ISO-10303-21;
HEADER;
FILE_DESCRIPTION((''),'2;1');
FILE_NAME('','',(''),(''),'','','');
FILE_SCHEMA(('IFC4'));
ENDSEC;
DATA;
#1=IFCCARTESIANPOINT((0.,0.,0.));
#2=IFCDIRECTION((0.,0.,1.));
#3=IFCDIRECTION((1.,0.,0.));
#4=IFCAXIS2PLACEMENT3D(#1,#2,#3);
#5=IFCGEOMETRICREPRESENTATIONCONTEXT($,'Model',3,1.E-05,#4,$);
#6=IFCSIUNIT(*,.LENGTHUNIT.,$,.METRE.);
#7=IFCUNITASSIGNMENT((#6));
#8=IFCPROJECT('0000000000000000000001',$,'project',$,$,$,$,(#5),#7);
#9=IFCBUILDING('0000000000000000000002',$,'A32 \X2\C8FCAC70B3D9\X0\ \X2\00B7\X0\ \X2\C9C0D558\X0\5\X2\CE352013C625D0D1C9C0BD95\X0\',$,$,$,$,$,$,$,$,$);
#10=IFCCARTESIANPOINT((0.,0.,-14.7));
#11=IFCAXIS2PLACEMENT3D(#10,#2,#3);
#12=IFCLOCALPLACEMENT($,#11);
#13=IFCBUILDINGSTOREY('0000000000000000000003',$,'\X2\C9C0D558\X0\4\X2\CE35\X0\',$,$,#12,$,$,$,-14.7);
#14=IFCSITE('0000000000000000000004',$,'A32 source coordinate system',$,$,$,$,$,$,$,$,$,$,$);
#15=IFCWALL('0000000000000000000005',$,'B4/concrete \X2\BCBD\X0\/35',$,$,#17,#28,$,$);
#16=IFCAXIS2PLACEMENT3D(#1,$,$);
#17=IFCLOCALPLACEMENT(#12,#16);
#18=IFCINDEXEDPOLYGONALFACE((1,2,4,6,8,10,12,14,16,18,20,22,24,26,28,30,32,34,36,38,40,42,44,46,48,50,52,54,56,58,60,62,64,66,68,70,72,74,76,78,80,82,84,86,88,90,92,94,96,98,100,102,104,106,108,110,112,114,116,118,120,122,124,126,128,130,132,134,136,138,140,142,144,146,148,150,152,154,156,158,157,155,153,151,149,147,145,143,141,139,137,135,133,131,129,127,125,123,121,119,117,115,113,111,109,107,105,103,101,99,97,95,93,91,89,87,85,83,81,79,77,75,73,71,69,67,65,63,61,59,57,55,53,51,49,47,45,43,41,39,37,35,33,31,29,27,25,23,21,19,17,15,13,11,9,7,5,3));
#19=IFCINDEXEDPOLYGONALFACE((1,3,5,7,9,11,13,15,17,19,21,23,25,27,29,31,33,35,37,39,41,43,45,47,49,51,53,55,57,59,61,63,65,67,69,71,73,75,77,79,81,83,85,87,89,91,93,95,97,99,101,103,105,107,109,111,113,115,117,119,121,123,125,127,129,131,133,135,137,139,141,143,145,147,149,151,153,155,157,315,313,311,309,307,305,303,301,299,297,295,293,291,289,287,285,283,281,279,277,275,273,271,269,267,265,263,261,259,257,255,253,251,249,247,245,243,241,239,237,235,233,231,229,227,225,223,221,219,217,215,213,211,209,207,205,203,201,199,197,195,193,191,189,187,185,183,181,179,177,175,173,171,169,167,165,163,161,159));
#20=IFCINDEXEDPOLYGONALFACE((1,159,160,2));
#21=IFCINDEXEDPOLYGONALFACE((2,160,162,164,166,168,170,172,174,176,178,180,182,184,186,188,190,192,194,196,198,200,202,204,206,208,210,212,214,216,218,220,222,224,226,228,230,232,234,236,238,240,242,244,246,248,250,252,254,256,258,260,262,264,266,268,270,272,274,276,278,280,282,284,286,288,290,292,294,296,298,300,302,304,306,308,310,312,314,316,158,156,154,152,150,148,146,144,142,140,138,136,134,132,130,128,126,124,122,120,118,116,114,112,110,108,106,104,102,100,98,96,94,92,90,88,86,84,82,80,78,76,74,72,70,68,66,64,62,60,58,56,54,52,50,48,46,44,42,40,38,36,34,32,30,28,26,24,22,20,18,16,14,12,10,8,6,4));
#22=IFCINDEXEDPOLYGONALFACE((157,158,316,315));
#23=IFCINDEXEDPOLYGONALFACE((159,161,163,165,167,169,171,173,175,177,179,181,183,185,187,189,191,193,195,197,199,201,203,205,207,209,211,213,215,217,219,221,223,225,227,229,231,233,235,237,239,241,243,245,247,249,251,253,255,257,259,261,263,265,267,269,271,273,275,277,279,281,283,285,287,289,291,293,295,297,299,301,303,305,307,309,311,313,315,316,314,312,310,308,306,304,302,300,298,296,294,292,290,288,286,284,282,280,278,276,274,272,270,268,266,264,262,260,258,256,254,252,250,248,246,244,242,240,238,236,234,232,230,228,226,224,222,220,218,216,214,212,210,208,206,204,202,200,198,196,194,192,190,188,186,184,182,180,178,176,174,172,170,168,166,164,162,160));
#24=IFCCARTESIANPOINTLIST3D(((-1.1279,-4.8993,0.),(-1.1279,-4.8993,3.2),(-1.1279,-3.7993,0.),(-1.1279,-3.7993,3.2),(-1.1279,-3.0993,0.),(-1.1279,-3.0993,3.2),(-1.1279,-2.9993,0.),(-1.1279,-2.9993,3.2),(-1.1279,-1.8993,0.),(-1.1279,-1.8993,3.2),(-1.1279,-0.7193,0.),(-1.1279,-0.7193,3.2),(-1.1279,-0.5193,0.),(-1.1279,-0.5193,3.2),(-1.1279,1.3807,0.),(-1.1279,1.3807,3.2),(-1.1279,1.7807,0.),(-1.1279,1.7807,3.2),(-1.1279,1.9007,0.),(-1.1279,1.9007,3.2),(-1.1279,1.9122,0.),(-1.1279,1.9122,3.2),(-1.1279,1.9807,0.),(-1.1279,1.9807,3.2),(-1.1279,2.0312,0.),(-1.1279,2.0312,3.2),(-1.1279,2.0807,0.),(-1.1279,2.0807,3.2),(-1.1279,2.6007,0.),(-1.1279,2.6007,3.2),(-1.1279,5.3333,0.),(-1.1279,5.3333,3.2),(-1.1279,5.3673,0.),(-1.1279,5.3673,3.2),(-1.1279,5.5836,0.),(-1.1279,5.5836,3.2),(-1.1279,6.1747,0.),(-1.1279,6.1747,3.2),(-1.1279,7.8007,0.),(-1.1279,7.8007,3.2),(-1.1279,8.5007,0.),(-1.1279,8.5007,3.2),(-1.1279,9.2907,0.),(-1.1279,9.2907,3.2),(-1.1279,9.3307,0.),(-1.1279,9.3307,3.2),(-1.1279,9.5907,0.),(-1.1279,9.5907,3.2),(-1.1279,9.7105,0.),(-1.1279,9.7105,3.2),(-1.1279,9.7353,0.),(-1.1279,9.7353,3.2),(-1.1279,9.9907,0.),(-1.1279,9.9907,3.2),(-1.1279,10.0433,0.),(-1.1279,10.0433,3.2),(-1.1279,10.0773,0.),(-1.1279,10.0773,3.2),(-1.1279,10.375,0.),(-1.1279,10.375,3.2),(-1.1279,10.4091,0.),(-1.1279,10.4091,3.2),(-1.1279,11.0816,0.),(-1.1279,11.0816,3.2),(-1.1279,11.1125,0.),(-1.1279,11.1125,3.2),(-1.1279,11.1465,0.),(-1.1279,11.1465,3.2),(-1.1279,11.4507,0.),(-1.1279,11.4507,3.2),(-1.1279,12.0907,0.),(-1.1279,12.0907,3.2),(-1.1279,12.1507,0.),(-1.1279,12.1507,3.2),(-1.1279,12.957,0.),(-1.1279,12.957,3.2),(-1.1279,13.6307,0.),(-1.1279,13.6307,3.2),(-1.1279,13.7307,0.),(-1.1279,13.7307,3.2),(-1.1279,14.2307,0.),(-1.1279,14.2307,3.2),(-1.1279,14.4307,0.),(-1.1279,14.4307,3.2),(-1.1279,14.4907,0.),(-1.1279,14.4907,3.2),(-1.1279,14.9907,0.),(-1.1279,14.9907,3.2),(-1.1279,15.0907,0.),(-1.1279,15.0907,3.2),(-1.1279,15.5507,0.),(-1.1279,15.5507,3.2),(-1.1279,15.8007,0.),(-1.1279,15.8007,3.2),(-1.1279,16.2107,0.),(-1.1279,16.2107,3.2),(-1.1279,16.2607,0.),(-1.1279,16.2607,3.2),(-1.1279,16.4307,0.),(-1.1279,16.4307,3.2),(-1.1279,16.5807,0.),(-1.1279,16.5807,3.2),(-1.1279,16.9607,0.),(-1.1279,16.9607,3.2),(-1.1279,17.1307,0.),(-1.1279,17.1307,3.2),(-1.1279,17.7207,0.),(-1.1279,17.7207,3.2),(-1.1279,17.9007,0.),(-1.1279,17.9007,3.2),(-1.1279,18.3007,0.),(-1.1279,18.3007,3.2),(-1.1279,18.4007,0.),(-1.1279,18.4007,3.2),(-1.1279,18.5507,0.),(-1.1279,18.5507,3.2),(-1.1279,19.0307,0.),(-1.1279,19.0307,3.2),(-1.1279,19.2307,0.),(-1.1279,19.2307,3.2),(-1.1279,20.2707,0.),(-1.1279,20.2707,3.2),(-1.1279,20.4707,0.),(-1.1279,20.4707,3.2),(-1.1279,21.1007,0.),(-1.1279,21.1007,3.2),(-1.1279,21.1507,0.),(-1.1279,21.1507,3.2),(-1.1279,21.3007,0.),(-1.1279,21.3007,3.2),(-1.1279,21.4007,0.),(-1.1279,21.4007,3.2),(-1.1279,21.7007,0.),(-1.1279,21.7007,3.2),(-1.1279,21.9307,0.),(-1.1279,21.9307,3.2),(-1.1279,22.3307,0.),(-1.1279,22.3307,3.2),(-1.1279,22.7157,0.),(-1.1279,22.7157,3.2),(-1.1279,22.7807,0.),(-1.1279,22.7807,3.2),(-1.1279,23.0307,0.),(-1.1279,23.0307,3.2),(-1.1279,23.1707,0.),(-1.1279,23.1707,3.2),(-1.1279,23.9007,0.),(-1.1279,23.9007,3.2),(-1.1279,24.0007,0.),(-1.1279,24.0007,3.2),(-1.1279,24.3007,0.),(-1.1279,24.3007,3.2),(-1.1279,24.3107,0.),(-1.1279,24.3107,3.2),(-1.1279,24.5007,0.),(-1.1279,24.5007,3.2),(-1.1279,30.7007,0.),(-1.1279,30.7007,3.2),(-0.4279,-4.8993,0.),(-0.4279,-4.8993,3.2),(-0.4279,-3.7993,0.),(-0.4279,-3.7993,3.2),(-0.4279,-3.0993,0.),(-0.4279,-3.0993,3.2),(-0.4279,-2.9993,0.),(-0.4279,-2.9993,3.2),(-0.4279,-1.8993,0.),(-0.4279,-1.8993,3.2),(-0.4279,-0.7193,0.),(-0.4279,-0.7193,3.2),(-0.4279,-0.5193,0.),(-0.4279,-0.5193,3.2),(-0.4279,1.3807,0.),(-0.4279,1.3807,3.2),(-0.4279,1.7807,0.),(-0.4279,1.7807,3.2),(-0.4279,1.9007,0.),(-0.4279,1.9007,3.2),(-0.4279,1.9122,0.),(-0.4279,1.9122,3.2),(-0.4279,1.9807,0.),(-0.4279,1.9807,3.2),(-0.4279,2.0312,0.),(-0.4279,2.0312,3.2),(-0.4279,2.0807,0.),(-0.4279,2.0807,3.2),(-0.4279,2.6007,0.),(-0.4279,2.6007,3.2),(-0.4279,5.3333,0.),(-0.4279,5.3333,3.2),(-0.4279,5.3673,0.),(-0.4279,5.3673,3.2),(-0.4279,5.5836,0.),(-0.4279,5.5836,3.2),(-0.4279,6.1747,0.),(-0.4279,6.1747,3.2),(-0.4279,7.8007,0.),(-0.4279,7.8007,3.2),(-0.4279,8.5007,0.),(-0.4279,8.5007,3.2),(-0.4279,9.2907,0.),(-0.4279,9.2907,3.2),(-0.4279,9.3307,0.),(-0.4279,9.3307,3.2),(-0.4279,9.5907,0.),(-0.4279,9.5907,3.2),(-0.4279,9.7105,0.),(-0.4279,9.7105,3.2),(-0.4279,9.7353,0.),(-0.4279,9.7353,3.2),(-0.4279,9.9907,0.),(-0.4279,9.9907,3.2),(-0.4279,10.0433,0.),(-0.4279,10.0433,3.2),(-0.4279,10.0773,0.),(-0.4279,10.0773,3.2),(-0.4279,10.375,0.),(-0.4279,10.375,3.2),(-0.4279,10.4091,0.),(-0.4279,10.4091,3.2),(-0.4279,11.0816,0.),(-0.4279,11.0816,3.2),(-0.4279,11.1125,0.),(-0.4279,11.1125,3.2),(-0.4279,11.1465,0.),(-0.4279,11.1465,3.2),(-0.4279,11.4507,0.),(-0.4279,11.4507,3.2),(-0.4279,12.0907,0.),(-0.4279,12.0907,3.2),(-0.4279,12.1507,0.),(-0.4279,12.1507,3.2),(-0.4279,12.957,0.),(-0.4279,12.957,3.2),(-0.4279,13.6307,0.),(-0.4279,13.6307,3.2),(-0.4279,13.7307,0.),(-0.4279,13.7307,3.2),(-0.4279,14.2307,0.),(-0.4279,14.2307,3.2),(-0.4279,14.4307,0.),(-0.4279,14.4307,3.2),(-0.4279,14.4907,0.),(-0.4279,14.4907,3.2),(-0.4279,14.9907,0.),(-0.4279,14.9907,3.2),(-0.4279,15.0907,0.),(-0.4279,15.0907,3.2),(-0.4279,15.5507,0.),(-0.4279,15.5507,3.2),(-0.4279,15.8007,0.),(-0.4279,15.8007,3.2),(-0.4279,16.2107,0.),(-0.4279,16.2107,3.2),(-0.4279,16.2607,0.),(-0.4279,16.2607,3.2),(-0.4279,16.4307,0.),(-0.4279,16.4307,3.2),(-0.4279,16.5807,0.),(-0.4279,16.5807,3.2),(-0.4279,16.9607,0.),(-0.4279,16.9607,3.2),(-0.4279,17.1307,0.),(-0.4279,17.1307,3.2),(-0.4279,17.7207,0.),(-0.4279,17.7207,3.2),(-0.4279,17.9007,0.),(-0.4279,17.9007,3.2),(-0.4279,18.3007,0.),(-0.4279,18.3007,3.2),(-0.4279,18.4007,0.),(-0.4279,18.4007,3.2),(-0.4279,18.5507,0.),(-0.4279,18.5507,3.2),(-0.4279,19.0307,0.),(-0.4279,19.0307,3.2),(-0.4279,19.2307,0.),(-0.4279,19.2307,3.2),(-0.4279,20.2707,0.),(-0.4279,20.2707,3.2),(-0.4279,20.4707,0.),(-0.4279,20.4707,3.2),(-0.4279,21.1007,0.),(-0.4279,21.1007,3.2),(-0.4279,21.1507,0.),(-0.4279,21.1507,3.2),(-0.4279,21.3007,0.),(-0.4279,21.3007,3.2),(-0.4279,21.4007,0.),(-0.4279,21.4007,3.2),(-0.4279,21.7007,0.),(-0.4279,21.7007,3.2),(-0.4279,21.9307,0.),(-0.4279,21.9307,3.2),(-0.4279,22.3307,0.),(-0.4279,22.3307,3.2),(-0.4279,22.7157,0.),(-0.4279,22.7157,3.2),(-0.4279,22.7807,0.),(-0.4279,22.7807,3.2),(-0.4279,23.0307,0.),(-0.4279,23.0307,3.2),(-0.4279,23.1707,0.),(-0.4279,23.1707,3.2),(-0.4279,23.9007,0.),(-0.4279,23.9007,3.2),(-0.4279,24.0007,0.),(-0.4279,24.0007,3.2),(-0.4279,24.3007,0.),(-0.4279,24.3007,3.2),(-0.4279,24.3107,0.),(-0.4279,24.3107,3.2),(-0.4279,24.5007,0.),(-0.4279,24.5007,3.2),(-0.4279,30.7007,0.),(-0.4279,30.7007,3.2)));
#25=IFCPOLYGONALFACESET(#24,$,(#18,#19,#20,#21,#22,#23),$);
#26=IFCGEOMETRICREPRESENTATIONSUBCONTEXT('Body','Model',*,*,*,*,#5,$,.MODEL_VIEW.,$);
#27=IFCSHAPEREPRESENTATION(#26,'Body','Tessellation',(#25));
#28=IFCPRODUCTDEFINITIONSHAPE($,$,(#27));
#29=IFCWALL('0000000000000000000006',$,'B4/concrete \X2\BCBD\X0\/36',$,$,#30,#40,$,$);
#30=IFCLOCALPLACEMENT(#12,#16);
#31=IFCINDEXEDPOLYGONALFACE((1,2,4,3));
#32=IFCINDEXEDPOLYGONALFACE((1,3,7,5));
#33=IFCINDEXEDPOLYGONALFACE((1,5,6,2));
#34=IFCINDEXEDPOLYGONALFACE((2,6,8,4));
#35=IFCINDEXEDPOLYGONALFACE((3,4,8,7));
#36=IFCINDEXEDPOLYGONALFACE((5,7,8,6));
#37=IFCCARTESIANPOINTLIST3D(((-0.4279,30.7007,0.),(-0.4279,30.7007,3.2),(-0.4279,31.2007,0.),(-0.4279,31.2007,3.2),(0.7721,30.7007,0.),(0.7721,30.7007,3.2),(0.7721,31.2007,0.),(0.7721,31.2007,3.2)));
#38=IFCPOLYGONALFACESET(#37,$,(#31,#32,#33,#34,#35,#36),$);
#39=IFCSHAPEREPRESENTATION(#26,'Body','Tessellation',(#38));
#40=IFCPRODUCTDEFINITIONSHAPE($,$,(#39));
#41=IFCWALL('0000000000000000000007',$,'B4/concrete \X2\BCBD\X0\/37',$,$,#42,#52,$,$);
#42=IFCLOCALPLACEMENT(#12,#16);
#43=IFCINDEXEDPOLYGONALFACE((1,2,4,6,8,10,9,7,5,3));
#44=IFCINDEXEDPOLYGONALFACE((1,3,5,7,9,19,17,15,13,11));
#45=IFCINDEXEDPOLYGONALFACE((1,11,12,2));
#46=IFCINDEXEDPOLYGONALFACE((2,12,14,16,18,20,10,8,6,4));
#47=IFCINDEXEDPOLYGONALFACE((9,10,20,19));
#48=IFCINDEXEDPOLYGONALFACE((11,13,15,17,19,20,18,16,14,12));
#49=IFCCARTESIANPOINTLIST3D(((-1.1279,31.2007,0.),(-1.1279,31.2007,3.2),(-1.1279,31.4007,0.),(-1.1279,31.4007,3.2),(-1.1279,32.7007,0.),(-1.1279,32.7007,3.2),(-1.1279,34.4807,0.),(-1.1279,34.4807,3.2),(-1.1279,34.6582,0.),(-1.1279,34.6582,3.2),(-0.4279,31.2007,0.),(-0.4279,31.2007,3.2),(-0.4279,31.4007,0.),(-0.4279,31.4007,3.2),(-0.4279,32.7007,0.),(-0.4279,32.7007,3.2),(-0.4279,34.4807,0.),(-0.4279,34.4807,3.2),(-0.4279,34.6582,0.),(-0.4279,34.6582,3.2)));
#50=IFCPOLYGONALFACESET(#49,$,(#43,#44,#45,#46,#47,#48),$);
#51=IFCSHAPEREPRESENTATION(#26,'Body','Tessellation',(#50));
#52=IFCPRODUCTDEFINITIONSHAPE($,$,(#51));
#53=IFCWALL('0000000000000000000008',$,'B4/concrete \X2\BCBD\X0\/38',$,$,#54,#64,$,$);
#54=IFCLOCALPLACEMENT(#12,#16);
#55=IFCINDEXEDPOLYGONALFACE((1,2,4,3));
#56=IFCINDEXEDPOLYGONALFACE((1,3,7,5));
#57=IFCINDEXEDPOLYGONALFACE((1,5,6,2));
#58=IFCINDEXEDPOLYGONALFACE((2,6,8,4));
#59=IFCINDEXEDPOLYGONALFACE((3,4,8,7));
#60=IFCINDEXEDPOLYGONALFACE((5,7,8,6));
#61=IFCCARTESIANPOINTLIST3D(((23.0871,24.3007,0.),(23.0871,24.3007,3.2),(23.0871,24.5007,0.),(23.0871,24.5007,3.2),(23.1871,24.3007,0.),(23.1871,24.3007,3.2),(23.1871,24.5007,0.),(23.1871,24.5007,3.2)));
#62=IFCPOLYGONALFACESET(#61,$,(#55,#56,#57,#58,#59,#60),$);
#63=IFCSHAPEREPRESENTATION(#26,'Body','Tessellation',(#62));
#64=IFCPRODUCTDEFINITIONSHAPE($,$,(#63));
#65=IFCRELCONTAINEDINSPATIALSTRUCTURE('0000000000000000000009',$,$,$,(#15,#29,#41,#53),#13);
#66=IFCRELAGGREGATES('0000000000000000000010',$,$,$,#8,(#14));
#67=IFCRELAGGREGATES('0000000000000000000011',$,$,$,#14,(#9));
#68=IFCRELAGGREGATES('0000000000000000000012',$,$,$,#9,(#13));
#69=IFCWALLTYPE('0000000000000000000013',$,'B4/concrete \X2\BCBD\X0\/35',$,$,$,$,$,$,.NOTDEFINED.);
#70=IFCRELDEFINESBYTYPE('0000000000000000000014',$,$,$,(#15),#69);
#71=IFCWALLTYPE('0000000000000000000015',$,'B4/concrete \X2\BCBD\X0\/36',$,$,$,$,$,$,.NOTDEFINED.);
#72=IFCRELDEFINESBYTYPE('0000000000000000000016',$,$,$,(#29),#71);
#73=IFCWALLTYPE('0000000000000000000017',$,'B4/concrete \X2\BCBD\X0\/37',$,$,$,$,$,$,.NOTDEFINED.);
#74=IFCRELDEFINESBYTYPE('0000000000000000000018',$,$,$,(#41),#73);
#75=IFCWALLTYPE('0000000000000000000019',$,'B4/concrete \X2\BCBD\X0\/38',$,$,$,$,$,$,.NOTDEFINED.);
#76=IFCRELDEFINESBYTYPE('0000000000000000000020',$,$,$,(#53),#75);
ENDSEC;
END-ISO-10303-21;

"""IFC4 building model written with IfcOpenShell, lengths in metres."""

from ifc_helpers import new_model, si_unit, frame, origin, origin_with_axes, place, context, subcontext, project, spatial, polyline, outline, extrude, source, transform, mapped, type_object, type_shapes, element, save


model = new_model("IFC4")

# Units and contexts
model_context = context("Model", 3, precision=1e-05, world=origin_with_axes())
body_context = subcontext(model_context, "Body", "Model", "MODEL_VIEW")
ifc_project = project(units=[si_unit("LENGTHUNIT", "METRE")], contexts=[model_context])

# Site, building, storey
site = spatial("IfcSite", under=ifc_project, Name="A32 source coordinate system")
building = spatial("IfcBuilding", under=site, Name="A32 주거동 · 지하5층–옥탑지붕")
storey_placement = place(None, frame((0.0, 0.0, -14.7), z_axis=(0.0, 0.0, 1.0), x_axis=(1.0, 0.0, 0.0)))
storey = spatial("IfcBuildingStorey", under=building, at=storey_placement, Name="지하4층", Elevation=-14.7)

# Walls
wall_type_1 = type_object("IfcWallType", Name="B4/concrete 벽/35", PredefinedType="NOTDEFINED")
shared_shape_1 = source(origin(), body_context, "Body", "SweptSolid", [
    extrude(outline(polyline([(-1.1279, -3.0993), (-1.1279, -2.9993), (-1.1279, -1.8993), (-1.1279, -0.7193), (-1.1279, -0.5193), (-1.1279, 1.3807), (-1.1279, 1.7807), (-1.1279, 1.9007), (-1.1279, 1.9122), (-1.1279, 1.9807), (-1.1279, 2.0312), (-1.1279, 2.0807), (-1.1279, 2.6007), (-1.1279, 5.3333), (-1.1279, 5.3673), (-1.1279, 5.5836), (-1.1279, 6.1747), (-1.1279, 7.8007), (-1.1279, 8.5007), (-1.1279, 9.2907), (-1.1279, 9.3307), (-1.1279, 9.5907), (-1.1279, 9.7105), (-1.1279, 9.7353), (-1.1279, 9.9907), (-1.1279, 10.0433), (-1.1279, 10.0773), (-1.1279, 10.375), (-1.1279, 10.4091), (-1.1279, 11.0816), (-1.1279, 11.1125), (-1.1279, 11.1465), (-1.1279, 11.4507), (-1.1279, 12.0907), (-1.1279, 12.1507), (-1.1279, 12.957), (-1.1279, 13.6307), (-1.1279, 13.7307), (-1.1279, 14.2307), (-1.1279, 14.4307), (-1.1279, 14.4907), (-1.1279, 14.9907), (-1.1279, 15.0907), (-1.1279, 15.5507), (-1.1279, 15.8007), (-1.1279, 16.2107), (-1.1279, 16.2607), (-1.1279, 16.4307), (-1.1279, 16.5807), (-1.1279, 16.9607), (-1.1279, 17.1307), (-1.1279, 17.7207), (-1.1279, 17.9007), (-1.1279, 18.3007), (-1.1279, 18.4007), (-1.1279, 18.5507), (-1.1279, 19.0307), (-1.1279, 19.2307), (-1.1279, 20.2707), (-1.1279, 20.4707), (-1.1279, 21.1007), (-1.1279, 21.1507), (-1.1279, 21.3007), (-1.1279, 21.4007), (-1.1279, 21.7007), (-1.1279, 21.9307), (-1.1279, 22.3307), (-1.1279, 22.7157), (-1.1279, 22.7807), (-1.1279, 23.0307), (-1.1279, 23.1707), (-1.1279, 23.9007), (-1.1279, 24.0007), (-1.1279, 24.3007), (-1.1279, 24.3107), (-1.1279, 24.5007), (-1.1279, 30.7007), (-0.4279, 30.7007), (-0.4279, 24.5007), (-0.4279, 24.3107), (-0.4279, 24.3007), (-0.4279, 24.0007), (-0.4279, 23.9007), (-0.4279, 23.1707), (-0.4279, 23.0307), (-0.4279, 22.7807), (-0.4279, 22.7157), (-0.4279, 22.3307), (-0.4279, 21.9307), (-0.4279, 21.7007), (-0.4279, 21.4007), (-0.4279, 21.3007), (-0.4279, 21.1507), (-0.4279, 21.1007), (-0.4279, 20.4707), (-0.4279, 20.2707), (-0.4279, 19.2307), (-0.4279, 19.0307), (-0.4279, 18.5507), (-0.4279, 18.4007), (-0.4279, 18.3007), (-0.4279, 17.9007), (-0.4279, 17.7207), (-0.4279, 17.1307), (-0.4279, 16.9607), (-0.4279, 16.5807), (-0.4279, 16.4307), (-0.4279, 16.2607), (-0.4279, 16.2107), (-0.4279, 15.8007), (-0.4279, 15.5507), (-0.4279, 15.0907), (-0.4279, 14.9907), (-0.4279, 14.4907), (-0.4279, 14.4307), (-0.4279, 14.2307), (-0.4279, 13.7307), (-0.4279, 13.6307), (-0.4279, 12.957), (-0.4279, 12.1507), (-0.4279, 12.0907), (-0.4279, 11.4507), (-0.4279, 11.1465), (-0.4279, 11.1125), (-0.4279, 11.0816), (-0.4279, 10.4091), (-0.4279, 10.375), (-0.4279, 10.0773), (-0.4279, 10.0433), (-0.4279, 9.9907), (-0.4279, 9.7353), (-0.4279, 9.7105), (-0.4279, 9.5907), (-0.4279, 9.3307), (-0.4279, 9.2907), (-0.4279, 8.5007), (-0.4279, 7.8007), (-0.4279, 6.1747), (-0.4279, 5.5836), (-0.4279, 5.3673), (-0.4279, 5.3333), (-0.4279, 2.6007), (-0.4279, 2.0807), (-0.4279, 2.0312), (-0.4279, 1.9807), (-0.4279, 1.9122), (-0.4279, 1.9007), (-0.4279, 1.7807), (-0.4279, 1.3807), (-0.4279, -0.5193), (-0.4279, -0.7193), (-0.4279, -1.8993), (-0.4279, -2.9993), (-0.4279, -3.0993), (-0.4279, -3.7993), (-0.4279, -4.8993), (-1.1279, -4.8993), (-1.1279, -3.7993), (-1.1279, -3.0993)])), origin(), (0.0, 0.0, 1.0), 3.2),
])
type_shapes(wall_type_1, [shared_shape_1])
wall_1_placement = place(storey_placement, origin_with_axes())
element("IfcWall", 1, at=wall_1_placement, inside=storey, type_object=wall_type_1, Name="B4/concrete 벽/35", context=body_context, shape_type="MappedRepresentation", body=[
    mapped(shared_shape_1, transform((0.0, 0.0, 0.0), scale=1.0)),
])
wall_type_2 = type_object("IfcWallType", Name="B4/concrete 벽/36", PredefinedType="NOTDEFINED")
shared_shape_2 = source(origin(), body_context, "Body", "SweptSolid", [
    extrude(outline(polyline([(0.7721, 30.7007), (-0.4279, 30.7007), (-0.4279, 31.2007), (0.7721, 31.2007), (0.7721, 30.7007)])), origin(), (0.0, 0.0, 1.0), 3.2),
])
type_shapes(wall_type_2, [shared_shape_2])
wall_2_placement = place(storey_placement, origin_with_axes())
element("IfcWall", 2, at=wall_2_placement, inside=storey, type_object=wall_type_2, Name="B4/concrete 벽/36", context=body_context, shape_type="MappedRepresentation", body=[
    mapped(shared_shape_2, transform((0.0, 0.0, 0.0), scale=1.0)),
])
wall_type_3 = type_object("IfcWallType", Name="B4/concrete 벽/37", PredefinedType="NOTDEFINED")
shared_shape_3 = source(origin(), body_context, "Body", "SweptSolid", [
    extrude(outline(polyline([(-1.1279, 32.7007), (-1.1279, 34.4807), (-1.1279, 34.6582), (-0.4279, 34.6582), (-0.4279, 34.4807), (-0.4279, 32.7007), (-0.4279, 31.4007), (-0.4279, 31.2007), (-1.1279, 31.2007), (-1.1279, 31.4007), (-1.1279, 32.7007)])), origin(), (0.0, 0.0, 1.0), 3.2),
])
type_shapes(wall_type_3, [shared_shape_3])
wall_3_placement = place(storey_placement, origin_with_axes())
element("IfcWall", 3, at=wall_3_placement, inside=storey, type_object=wall_type_3, Name="B4/concrete 벽/37", context=body_context, shape_type="MappedRepresentation", body=[
    mapped(shared_shape_3, transform((0.0, 0.0, 0.0), scale=1.0)),
])
wall_type_4 = type_object("IfcWallType", Name="B4/concrete 벽/38", PredefinedType="NOTDEFINED")
shared_shape_4 = source(origin(), body_context, "Body", "SweptSolid", [
    extrude(outline(polyline([(23.0871, 24.3007), (23.0871, 24.5007), (23.1871, 24.5007), (23.1871, 24.3007), (23.0871, 24.3007)])), origin(), (0.0, 0.0, 1.0), 3.2),
])
type_shapes(wall_type_4, [shared_shape_4])
wall_4_placement = place(storey_placement, origin_with_axes())
element("IfcWall", 4, at=wall_4_placement, inside=storey, type_object=wall_type_4, Name="B4/concrete 벽/38", context=body_context, shape_type="MappedRepresentation", body=[
    mapped(shared_shape_4, transform((0.0, 0.0, 0.0), scale=1.0)),
])

save(model, "model.ifc")
